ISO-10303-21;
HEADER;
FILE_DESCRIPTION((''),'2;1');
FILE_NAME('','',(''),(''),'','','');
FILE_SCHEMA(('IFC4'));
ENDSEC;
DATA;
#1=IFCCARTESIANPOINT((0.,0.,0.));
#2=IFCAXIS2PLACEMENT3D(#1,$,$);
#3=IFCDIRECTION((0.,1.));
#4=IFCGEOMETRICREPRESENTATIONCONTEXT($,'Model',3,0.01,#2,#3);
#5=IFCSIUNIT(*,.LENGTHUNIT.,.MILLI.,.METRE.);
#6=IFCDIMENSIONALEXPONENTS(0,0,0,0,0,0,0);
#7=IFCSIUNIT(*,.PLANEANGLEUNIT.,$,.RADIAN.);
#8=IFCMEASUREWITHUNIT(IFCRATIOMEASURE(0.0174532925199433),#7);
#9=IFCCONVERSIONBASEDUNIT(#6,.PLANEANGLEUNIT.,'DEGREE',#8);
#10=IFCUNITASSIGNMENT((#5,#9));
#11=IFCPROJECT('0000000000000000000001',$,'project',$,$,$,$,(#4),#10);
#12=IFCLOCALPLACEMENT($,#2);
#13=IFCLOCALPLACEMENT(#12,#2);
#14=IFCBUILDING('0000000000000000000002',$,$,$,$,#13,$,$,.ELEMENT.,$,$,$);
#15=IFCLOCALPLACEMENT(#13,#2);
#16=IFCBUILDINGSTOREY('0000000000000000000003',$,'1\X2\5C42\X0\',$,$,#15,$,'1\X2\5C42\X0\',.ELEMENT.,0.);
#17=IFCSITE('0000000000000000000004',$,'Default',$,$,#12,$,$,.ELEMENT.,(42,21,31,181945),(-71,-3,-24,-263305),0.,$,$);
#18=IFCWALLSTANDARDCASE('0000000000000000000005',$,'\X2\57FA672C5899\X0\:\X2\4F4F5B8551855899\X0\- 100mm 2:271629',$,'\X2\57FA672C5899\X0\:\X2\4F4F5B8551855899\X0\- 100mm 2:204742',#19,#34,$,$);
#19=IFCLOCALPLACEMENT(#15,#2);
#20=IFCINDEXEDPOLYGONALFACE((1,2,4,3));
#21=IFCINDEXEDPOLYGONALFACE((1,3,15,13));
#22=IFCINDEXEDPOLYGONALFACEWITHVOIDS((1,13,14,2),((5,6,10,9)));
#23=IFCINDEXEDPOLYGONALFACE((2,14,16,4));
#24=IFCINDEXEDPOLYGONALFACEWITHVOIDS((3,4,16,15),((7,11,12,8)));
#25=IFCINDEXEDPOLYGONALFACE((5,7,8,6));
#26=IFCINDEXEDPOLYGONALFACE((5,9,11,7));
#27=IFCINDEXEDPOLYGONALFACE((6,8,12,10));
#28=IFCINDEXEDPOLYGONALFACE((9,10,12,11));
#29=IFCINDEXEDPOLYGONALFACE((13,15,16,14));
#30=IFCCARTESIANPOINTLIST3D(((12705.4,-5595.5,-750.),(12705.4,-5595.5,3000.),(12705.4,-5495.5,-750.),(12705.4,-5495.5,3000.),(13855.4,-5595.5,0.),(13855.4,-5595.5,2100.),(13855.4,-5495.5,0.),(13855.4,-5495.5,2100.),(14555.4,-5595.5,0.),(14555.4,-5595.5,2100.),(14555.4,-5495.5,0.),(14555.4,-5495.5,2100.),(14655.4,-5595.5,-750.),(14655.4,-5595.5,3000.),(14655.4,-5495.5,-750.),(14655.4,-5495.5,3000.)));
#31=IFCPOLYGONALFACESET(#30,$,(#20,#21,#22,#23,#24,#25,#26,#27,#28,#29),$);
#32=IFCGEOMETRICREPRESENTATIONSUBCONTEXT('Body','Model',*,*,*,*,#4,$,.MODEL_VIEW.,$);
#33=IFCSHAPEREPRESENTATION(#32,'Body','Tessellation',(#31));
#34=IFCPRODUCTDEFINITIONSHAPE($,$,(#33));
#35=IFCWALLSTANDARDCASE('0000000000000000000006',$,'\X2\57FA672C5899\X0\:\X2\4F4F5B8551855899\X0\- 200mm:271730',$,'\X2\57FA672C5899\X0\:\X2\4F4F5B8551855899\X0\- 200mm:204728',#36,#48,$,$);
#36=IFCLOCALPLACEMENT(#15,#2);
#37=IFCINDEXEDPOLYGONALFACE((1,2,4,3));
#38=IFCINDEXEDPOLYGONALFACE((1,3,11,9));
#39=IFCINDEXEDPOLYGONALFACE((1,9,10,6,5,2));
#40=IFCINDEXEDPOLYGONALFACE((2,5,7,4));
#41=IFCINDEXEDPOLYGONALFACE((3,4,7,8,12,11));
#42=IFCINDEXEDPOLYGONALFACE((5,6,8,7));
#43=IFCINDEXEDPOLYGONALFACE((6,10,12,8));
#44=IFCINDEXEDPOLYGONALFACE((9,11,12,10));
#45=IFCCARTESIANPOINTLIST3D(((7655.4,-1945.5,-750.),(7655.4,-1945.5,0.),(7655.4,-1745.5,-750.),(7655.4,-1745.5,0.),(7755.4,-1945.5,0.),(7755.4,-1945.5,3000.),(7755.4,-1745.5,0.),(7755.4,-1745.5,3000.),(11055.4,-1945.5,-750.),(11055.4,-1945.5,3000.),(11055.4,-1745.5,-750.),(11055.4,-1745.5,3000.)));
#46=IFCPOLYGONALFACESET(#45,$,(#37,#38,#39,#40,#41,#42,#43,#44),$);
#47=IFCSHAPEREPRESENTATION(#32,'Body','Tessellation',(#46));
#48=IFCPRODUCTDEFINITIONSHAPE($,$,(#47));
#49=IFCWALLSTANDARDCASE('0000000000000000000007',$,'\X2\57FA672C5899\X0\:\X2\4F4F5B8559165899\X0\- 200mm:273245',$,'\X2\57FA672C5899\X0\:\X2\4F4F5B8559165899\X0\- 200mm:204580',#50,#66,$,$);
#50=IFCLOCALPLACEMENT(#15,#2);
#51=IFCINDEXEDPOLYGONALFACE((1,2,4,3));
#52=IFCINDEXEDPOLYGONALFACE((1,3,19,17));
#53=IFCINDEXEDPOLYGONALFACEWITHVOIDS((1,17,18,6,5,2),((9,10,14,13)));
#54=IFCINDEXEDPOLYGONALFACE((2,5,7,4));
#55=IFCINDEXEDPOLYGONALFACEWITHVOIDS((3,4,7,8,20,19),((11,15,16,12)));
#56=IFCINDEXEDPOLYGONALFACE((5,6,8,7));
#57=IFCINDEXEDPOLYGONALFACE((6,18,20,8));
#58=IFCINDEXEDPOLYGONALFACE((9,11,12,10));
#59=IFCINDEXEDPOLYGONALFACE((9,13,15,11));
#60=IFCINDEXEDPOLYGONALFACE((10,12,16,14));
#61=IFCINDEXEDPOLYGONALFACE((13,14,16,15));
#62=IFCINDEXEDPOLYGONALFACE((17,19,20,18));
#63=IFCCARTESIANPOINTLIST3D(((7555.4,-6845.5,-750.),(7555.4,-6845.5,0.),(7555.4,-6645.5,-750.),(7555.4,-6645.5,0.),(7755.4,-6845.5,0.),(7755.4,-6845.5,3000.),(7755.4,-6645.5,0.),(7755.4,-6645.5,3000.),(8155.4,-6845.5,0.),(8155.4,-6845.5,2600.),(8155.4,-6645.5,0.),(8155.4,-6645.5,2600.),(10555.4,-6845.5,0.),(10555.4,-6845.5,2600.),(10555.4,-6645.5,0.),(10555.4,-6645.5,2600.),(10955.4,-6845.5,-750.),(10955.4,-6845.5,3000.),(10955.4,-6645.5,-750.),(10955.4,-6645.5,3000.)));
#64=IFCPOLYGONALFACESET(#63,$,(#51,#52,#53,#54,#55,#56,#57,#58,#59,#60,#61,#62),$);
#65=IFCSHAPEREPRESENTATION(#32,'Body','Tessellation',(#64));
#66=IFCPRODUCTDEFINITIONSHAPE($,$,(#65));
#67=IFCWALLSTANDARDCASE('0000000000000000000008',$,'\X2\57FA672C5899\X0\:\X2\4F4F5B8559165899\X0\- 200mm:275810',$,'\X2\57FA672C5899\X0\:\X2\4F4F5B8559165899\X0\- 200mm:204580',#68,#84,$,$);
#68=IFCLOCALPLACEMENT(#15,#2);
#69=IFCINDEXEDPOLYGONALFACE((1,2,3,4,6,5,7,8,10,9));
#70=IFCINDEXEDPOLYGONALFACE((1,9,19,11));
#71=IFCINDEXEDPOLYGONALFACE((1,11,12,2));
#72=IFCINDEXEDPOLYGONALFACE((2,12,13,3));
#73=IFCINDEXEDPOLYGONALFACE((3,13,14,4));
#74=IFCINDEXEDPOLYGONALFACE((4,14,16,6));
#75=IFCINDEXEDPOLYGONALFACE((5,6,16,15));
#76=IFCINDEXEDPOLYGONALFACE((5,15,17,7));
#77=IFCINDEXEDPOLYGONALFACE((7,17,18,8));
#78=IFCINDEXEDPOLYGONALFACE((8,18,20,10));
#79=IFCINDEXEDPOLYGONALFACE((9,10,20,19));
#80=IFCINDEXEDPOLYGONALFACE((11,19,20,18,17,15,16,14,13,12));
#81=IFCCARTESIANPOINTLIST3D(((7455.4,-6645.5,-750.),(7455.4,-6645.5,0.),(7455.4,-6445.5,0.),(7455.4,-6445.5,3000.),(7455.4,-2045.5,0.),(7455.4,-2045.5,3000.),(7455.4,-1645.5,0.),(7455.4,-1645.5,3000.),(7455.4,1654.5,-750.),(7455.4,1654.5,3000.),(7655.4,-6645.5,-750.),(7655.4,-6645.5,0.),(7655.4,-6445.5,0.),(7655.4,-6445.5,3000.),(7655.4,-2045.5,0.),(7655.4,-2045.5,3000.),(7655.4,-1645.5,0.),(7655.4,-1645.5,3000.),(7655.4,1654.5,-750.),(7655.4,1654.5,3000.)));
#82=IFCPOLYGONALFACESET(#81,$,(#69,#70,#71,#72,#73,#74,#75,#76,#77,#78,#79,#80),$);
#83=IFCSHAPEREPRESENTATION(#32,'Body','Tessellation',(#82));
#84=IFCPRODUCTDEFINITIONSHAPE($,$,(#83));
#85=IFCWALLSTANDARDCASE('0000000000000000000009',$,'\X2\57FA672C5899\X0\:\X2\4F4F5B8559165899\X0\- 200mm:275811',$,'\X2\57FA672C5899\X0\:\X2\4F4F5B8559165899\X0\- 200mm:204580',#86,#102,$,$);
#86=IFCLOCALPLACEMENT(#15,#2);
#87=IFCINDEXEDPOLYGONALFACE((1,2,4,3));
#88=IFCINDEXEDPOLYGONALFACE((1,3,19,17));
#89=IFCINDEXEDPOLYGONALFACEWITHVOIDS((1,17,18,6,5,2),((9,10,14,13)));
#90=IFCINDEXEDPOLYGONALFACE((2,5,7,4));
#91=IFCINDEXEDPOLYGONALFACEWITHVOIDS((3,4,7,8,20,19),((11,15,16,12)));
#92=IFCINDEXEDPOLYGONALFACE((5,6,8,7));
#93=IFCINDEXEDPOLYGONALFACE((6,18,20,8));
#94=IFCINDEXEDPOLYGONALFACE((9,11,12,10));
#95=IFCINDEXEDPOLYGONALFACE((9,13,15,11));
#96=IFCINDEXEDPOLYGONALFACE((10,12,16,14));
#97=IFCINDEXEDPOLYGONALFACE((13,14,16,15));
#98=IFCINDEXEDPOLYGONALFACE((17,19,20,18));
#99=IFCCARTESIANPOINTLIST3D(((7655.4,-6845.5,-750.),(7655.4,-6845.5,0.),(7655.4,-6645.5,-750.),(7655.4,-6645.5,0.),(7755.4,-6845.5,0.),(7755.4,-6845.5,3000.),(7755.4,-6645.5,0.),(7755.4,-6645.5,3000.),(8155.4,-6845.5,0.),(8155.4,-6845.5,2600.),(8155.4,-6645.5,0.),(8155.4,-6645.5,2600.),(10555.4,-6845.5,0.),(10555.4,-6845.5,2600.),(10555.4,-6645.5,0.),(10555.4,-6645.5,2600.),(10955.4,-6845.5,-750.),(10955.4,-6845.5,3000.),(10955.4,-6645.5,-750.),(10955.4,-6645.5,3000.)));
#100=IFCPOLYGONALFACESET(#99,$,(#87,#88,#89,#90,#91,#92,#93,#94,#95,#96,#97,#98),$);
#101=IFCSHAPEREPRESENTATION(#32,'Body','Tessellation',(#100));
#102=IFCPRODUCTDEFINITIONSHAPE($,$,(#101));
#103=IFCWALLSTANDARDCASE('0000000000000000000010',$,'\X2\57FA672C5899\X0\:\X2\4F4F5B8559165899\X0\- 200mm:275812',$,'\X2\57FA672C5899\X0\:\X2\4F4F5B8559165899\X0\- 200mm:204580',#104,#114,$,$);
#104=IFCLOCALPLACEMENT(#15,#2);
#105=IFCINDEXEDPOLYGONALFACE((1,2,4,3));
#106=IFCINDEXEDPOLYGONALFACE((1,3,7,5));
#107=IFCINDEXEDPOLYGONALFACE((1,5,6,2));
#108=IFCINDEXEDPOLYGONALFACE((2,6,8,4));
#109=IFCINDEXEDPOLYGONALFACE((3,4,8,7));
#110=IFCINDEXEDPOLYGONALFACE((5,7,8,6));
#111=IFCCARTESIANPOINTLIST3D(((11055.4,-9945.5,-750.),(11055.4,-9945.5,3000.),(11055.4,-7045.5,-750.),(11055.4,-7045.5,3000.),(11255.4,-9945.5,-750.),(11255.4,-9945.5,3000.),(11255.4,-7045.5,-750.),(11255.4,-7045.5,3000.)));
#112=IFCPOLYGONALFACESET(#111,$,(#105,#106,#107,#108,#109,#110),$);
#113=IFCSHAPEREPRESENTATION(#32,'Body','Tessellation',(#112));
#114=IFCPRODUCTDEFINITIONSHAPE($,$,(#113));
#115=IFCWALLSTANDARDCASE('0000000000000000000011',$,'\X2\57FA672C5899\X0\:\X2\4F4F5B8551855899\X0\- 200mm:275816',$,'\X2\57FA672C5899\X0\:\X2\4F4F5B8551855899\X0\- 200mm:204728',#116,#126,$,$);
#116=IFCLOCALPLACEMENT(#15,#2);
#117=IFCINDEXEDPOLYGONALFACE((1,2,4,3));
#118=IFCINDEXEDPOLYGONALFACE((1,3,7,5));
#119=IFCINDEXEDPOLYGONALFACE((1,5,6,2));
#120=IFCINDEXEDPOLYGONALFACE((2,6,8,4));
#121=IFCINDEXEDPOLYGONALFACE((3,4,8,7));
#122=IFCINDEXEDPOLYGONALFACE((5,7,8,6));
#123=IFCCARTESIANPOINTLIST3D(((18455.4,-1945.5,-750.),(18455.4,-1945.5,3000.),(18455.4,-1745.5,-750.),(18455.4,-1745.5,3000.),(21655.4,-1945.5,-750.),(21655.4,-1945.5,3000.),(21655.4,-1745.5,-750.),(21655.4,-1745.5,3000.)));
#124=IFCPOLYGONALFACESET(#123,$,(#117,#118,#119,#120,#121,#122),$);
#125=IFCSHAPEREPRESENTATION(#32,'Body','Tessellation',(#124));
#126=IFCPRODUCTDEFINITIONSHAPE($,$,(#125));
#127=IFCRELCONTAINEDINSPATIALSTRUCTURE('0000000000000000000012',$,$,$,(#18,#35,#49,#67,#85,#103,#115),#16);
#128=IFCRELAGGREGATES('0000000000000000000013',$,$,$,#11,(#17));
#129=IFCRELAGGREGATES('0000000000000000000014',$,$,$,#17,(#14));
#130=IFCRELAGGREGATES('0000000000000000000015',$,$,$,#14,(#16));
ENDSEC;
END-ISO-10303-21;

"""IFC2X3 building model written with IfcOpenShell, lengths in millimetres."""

from ifc_helpers import new_model, entity, si_unit, converted_unit, direction, frame, frame_2d, origin, place, context, subcontext, project, spatial, polyline, rectangle, extrude, clip, bounded_halfspace, element, save


model = new_model("IFC2X3")

# Units and contexts
model_context = context("Model", 3, precision=0.01, world=origin(), true_north=direction((0.0, 1.0)))
body_context = subcontext(model_context, "Body", "Model", "MODEL_VIEW")
ifc_project = project(units=[si_unit("LENGTHUNIT", "METRE", prefix="MILLI"), converted_unit("PLANEANGLEUNIT", "DEGREE", entity("IfcRatioMeasure", 0.0174532925199433), si_unit("PLANEANGLEUNIT", "RADIAN"), dimensions=[0, 0, 0, 0, 0, 0, 0])], contexts=[model_context])

# Site, building, storey
site_placement = place(None, origin())
site = spatial("IfcSite", under=ifc_project, at=site_placement, Name="Default", CompositionType="ELEMENT", RefLatitude=(42, 21, 31, 181945), RefLongitude=(-71, -3, -24, -263305), RefElevation=0.0)
building_placement = place(site_placement, origin())
building = spatial("IfcBuilding", under=site, at=building_placement, CompositionType="ELEMENT")
storey_placement = place(building_placement, origin())
storey = spatial("IfcBuildingStorey", under=building, at=storey_placement, Name="1层", LongName="1层", CompositionType="ELEMENT", Elevation=0.0)

# Wall, openings
wall_1_placement = place(storey_placement, frame((12705.4, -5545.5, -750.0)))
wall_1 = element("IfcWallStandardCase", 1, at=wall_1_placement, inside=storey, Name="基本墙:住宅内墙- 100mm 2:271629", ObjectType="基本墙:住宅内墙- 100mm 2:204742", context=body_context, shape_type="SweptSolid", body=[
    extrude(rectangle(XDim=1950.0, YDim=100.0, at=frame_2d((975.0, 0.0), x_axis=(-1.0, 0.0))), origin(), (0.0, 0.0, 1.0), 3750.0),
])
opening_1_placement = place(wall_1_placement, frame((1150.0, -50.0, 750.0)))
element("IfcOpeningElement", 2, at=opening_1_placement, cuts=wall_1, ObjectType="Opening", context=body_context, shape_type="SweptSolid", body=[
    extrude(rectangle(XDim=2100.0, YDim=700.0, at=frame_2d((1050.0, 350.0), x_axis=(1.0, 0.0))), frame((0.0, 0.0, 0.0), z_axis=(0.0, 1.0, 0.0), x_axis=(0.0, 0.0, 1.0)), (0.0, 0.0, 1.0), 100.0),
])
opening_2_placement = place(wall_1_placement, origin())
element("IfcOpeningElement", 3, at=opening_2_placement, cuts=wall_1, ObjectType="Opening", context=body_context, shape_type="SweptSolid", body=[
    extrude(rectangle(XDim=2100.0, YDim=700.0, at=frame_2d((0.0, 0.0), x_axis=(0.0, 1.0))), frame((1500.0, -1574.0, 4800.0), z_axis=(0.0, 1.0, 0.0), x_axis=(-1.0, 0.0, 0.0)), (0.0, 0.0, 1.0), 3048.0),
])

# Wall
wall_2_placement = place(storey_placement, frame((11055.4, -1845.5, -750.0), z_axis=(0.0, 0.0, 1.0), x_axis=(-1.0, 0.0, 0.0)))
element("IfcWallStandardCase", 4, at=wall_2_placement, inside=storey, Name="基本墙:住宅内墙- 200mm:271730", ObjectType="基本墙:住宅内墙- 200mm:204728", context=body_context, shape_type="Clipping", body=[
    clip(clip(extrude(rectangle(XDim=3400.0, YDim=200.0, at=frame_2d((1700.0, 0.0), x_axis=(-1.0, 0.0))), origin(), (0.0, 0.0, 1.0), 3750.0), bounded_halfspace(frame((3300.0, 100.0, 750.0), z_axis=(0.0, 0.0, -1.0), x_axis=(-1.0, 0.0, 0.0)), True, frame((3300.0, 100.0, 750.0), z_axis=(0.0, 0.0, -1.0), x_axis=(-1.0, 0.0, 0.0)), polyline([(0.0, 0.0), (-100.0, 0.0), (-100.0, -200.0), (0.0, -200.0), (0.0, 0.0)]))), bounded_halfspace(frame((3300.0, -100.0, 750.0), z_axis=(-1.0, 0.0, 0.0), x_axis=(0.0, 0.0, -1.0)), True, frame((3300.0, -100.0, 750.0), z_axis=(-1.0, 0.0, 0.0), x_axis=(0.0, 0.0, -1.0)), polyline([(0.0, 0.0), (-3000.0, 0.0), (-3000.0, -200.0), (0.0, -200.0), (0.0, 0.0)]))),
])

# Wall, openings
wall_3_placement = place(storey_placement, frame((7555.4, -6745.5, -750.0)))
wall_3 = element("IfcWallStandardCase", 5, at=wall_3_placement, inside=storey, Name="基本墙:住宅外墙- 200mm:273245", ObjectType="基本墙:住宅外墙- 200mm:204580", context=body_context, shape_type="Clipping", body=[
    clip(clip(clip(extrude(rectangle(XDim=3400.0, YDim=200.0, at=frame_2d((1700.0, 0.0), x_axis=(-1.0, 0.0))), origin(), (0.0, 0.0, 1.0), 3750.0), bounded_halfspace(frame((3400.0, -100.0, 3750.0), z_axis=(-1.0, 0.0, 0.0), x_axis=(0.0, 0.0, -1.0)), True, frame((3400.0, -100.0, 3750.0), z_axis=(-1.0, 0.0, 0.0), x_axis=(0.0, 0.0, -1.0)), polyline([(0.0, 0.0), (0.0, -200.0), (3750.0, -200.0), (3750.0, 0.0), (0.0, 0.0)]))), bounded_halfspace(frame((200.0, -100.0, 750.0), z_axis=(0.0, 0.0, -1.0), x_axis=(1.0, 0.0, 0.0)), True, frame((200.0, -100.0, 750.0), z_axis=(0.0, 0.0, -1.0), x_axis=(1.0, 0.0, 0.0)), polyline([(0.0, 0.0), (-200.0, 0.0), (-200.0, -200.0), (-100.0, -200.0), (0.0, -200.0), (0.0, 0.0)]))), bounded_halfspace(frame((200.0, 100.0, 750.0), z_axis=(1.0, 0.0, 0.0), x_axis=(0.0, 0.0, -1.0)), True, frame((200.0, 100.0, 750.0), z_axis=(1.0, 0.0, 0.0), x_axis=(0.0, 0.0, -1.0)), polyline([(0.0, 0.0), (-3000.0, 0.0), (-3000.0, -200.0), (0.0, -200.0), (0.0, 0.0)]))),
])
opening_3_placement = place(wall_3_placement, frame((3000.0, 100.0, 750.0)))
element("IfcOpeningElement", 6, at=opening_3_placement, cuts=wall_3, ObjectType="Opening", context=body_context, shape_type="SweptSolid", body=[
    extrude(rectangle(XDim=2600.0, YDim=2400.0, at=frame_2d((1300.0, 1200.0), x_axis=(1.0, 0.0))), frame((0.0, 0.0, 0.0), z_axis=(0.0, -1.0, 0.0), x_axis=(0.0, 0.0, 1.0)), (0.0, 0.0, 1.0), 200.0),
])
opening_4_placement = place(wall_3_placement, origin())
element("IfcOpeningElement", 7, at=opening_4_placement, cuts=wall_3, ObjectType="Opening", context=body_context, shape_type="SweptSolid", body=[
    extrude(rectangle(XDim=2600.0, YDim=2400.0, at=frame_2d((0.0, 0.0), x_axis=(0.0, 1.0))), frame((1800.0, -1424.0, 5050.0), z_axis=(0.0, 1.0, 0.0), x_axis=(-1.0, 0.0, 0.0)), (0.0, 0.0, 1.0), 3048.0),
])

# Wall
wall_4_placement = place(storey_placement, frame((7555.4, 1654.5, -750.0), z_axis=(0.0, 0.0, 1.0), x_axis=(0.0, -1.0, 0.0)))
element("IfcWallStandardCase", 8, at=wall_4_placement, inside=storey, Name="基本墙:住宅外墙- 200mm:275810", ObjectType="基本墙:住宅外墙- 200mm:204580", context=body_context, shape_type="Clipping", body=[
    clip(clip(clip(extrude(rectangle(XDim=8300.0, YDim=200.0, at=frame_2d((4150.0, 0.0), x_axis=(-1.0, 0.0))), origin(), (0.0, 0.0, 1.0), 3750.0), bounded_halfspace(frame((3300.0, 100.0, 750.0), z_axis=(0.0, 0.0, -1.0), x_axis=(0.0, 1.0, 0.0)), True, frame((3300.0, 100.0, 750.0), z_axis=(0.0, 0.0, -1.0), x_axis=(0.0, 1.0, 0.0)), polyline([(0.0, 0.0), (0.0, 100.0), (0.0, 300.0), (0.0, 400.0), (-200.0, 400.0), (-200.0, 0.0), (0.0, 0.0)]))), bounded_halfspace(frame((8100.0, 100.0, 750.0), z_axis=(0.0, 0.0, -1.0), x_axis=(0.0, 1.0, 0.0)), True, frame((8100.0, 100.0, 750.0), z_axis=(0.0, 0.0, -1.0), x_axis=(0.0, 1.0, 0.0)), polyline([(0.0, 0.0), (0.0, 200.0), (-100.0, 200.0), (-200.0, 200.0), (-200.0, 0.0), (0.0, 0.0)]))), bounded_halfspace(frame((8100.0, -100.0, 750.0), z_axis=(-1.0, 0.0, 0.0), x_axis=(0.0, 0.0, -1.0)), True, frame((8100.0, -100.0, 750.0), z_axis=(-1.0, 0.0, 0.0), x_axis=(0.0, 0.0, -1.0)), polyline([(0.0, 0.0), (-3000.0, 0.0), (-3000.0, -200.0), (0.0, -200.0), (0.0, 0.0)]))),
])

# Wall, openings
wall_5_placement = place(storey_placement, frame((7655.4, -6745.5, -750.0)))
wall_5 = element("IfcWallStandardCase", 9, at=wall_5_placement, inside=storey, Name="基本墙:住宅外墙- 200mm:275811", ObjectType="基本墙:住宅外墙- 200mm:204580", context=body_context, shape_type="Clipping", body=[
    clip(clip(clip(extrude(rectangle(XDim=3300.0, YDim=200.0, at=frame_2d((1650.0, 0.0), x_axis=(-1.0, 0.0))), origin(), (0.0, 0.0, 1.0), 3750.0), bounded_halfspace(frame((3300.0, -100.0, 3750.0), z_axis=(-1.0, 0.0, 0.0), x_axis=(0.0, 0.0, -1.0)), True, frame((3300.0, -100.0, 3750.0), z_axis=(-1.0, 0.0, 0.0), x_axis=(0.0, 0.0, -1.0)), polyline([(0.0, 0.0), (0.0, -200.0), (3750.0, -200.0), (3750.0, 0.0), (0.0, 0.0)]))), bounded_halfspace(frame((100.0, -100.0, 750.0), z_axis=(0.0, 0.0, -1.0), x_axis=(1.0, 0.0, 0.0)), True, frame((100.0, -100.0, 750.0), z_axis=(0.0, 0.0, -1.0), x_axis=(1.0, 0.0, 0.0)), polyline([(0.0, 0.0), (-100.0, 0.0), (-100.0, -200.0), (0.0, -200.0), (0.0, 0.0)]))), bounded_halfspace(frame((100.0, 100.0, 750.0), z_axis=(1.0, 0.0, 0.0), x_axis=(0.0, 0.0, -1.0)), True, frame((100.0, 100.0, 750.0), z_axis=(1.0, 0.0, 0.0), x_axis=(0.0, 0.0, -1.0)), polyline([(0.0, 0.0), (-3000.0, 0.0), (-3000.0, -200.0), (0.0, -200.0), (0.0, 0.0)]))),
])
opening_5_placement = place(wall_5_placement, frame((2900.0, 100.0, 750.0)))
element("IfcOpeningElement", 10, at=opening_5_placement, cuts=wall_5, ObjectType="Opening", context=body_context, shape_type="SweptSolid", body=[
    extrude(rectangle(XDim=2600.0, YDim=2400.0, at=frame_2d((1300.0, 1200.0), x_axis=(1.0, 0.0))), frame((0.0, 0.0, 0.0), z_axis=(0.0, -1.0, 0.0), x_axis=(0.0, 0.0, 1.0)), (0.0, 0.0, 1.0), 200.0),
])
opening_6_placement = place(wall_5_placement, origin())
element("IfcOpeningElement", 11, at=opening_6_placement, cuts=wall_5, ObjectType="Opening", context=body_context, shape_type="SweptSolid", body=[
    extrude(rectangle(XDim=2600.0, YDim=2400.0, at=frame_2d((0.0, 0.0), x_axis=(0.0, 1.0))), frame((1700.0, -1424.0, 5050.0), z_axis=(0.0, 1.0, 0.0), x_axis=(-1.0, 0.0, 0.0)), (0.0, 0.0, 1.0), 3048.0),
])

# Walls
wall_6_placement = place(storey_placement, frame((11155.4, -7045.5, -750.0), z_axis=(0.0, 0.0, 1.0), x_axis=(0.0, -1.0, 0.0)))
element("IfcWallStandardCase", 12, at=wall_6_placement, inside=storey, Name="基本墙:住宅外墙- 200mm:275812", ObjectType="基本墙:住宅外墙- 200mm:204580", context=body_context, shape_type="Clipping", body=[
    clip(clip(extrude(rectangle(XDim=2900.0, YDim=200.0, at=frame_2d((1450.0, 0.0), x_axis=(-1.0, 0.0))), origin(), (0.0, 0.0, 1.0), 3750.0), bounded_halfspace(frame((0.0, -100.0, 0.0), z_axis=(1.0, 0.0, 0.0), x_axis=(0.0, 0.0, -1.0)), True, frame((0.0, -100.0, 0.0), z_axis=(1.0, 0.0, 0.0), x_axis=(0.0, 0.0, -1.0)), polyline([(0.0, 0.0), (0.0, 200.0), (-3750.0, 200.0), (-3750.0, 0.0), (0.0, 0.0)]))), bounded_halfspace(frame((2900.0, -100.0, 3750.0), z_axis=(-1.0, 0.0, 0.0), x_axis=(0.0, 0.0, -1.0)), True, frame((2900.0, -100.0, 3750.0), z_axis=(-1.0, 0.0, 0.0), x_axis=(0.0, 0.0, -1.0)), polyline([(0.0, 0.0), (0.0, -200.0), (3750.0, -200.0), (3750.0, 0.0), (0.0, 0.0)]))),
])
wall_7_placement = place(storey_placement, frame((21655.4, -1845.5, -750.0), z_axis=(0.0, 0.0, 1.0), x_axis=(-1.0, 0.0, 0.0)))
element("IfcWallStandardCase", 13, at=wall_7_placement, inside=storey, Name="基本墙:住宅内墙- 200mm:275816", ObjectType="基本墙:住宅内墙- 200mm:204728", context=body_context, shape_type="Clipping", body=[
    clip(extrude(rectangle(XDim=3200.0, YDim=200.0, at=frame_2d((1600.0, 0.0), x_axis=(-1.0, 0.0))), origin(), (0.0, 0.0, 1.0), 3750.0), bounded_halfspace(frame((0.0, -100.0, 0.0), z_axis=(-1.0, 0.0, 0.0), x_axis=(0.0, 0.0, -1.0)), False, frame((0.0, -100.0, 0.0), z_axis=(-1.0, 0.0, 0.0), x_axis=(0.0, 0.0, -1.0)), polyline([(0.0, 0.0), (-3750.0, 0.0), (-3750.0, -200.0), (0.0, -200.0), (0.0, 0.0)]))),
])

save(model, "model.ifc")
